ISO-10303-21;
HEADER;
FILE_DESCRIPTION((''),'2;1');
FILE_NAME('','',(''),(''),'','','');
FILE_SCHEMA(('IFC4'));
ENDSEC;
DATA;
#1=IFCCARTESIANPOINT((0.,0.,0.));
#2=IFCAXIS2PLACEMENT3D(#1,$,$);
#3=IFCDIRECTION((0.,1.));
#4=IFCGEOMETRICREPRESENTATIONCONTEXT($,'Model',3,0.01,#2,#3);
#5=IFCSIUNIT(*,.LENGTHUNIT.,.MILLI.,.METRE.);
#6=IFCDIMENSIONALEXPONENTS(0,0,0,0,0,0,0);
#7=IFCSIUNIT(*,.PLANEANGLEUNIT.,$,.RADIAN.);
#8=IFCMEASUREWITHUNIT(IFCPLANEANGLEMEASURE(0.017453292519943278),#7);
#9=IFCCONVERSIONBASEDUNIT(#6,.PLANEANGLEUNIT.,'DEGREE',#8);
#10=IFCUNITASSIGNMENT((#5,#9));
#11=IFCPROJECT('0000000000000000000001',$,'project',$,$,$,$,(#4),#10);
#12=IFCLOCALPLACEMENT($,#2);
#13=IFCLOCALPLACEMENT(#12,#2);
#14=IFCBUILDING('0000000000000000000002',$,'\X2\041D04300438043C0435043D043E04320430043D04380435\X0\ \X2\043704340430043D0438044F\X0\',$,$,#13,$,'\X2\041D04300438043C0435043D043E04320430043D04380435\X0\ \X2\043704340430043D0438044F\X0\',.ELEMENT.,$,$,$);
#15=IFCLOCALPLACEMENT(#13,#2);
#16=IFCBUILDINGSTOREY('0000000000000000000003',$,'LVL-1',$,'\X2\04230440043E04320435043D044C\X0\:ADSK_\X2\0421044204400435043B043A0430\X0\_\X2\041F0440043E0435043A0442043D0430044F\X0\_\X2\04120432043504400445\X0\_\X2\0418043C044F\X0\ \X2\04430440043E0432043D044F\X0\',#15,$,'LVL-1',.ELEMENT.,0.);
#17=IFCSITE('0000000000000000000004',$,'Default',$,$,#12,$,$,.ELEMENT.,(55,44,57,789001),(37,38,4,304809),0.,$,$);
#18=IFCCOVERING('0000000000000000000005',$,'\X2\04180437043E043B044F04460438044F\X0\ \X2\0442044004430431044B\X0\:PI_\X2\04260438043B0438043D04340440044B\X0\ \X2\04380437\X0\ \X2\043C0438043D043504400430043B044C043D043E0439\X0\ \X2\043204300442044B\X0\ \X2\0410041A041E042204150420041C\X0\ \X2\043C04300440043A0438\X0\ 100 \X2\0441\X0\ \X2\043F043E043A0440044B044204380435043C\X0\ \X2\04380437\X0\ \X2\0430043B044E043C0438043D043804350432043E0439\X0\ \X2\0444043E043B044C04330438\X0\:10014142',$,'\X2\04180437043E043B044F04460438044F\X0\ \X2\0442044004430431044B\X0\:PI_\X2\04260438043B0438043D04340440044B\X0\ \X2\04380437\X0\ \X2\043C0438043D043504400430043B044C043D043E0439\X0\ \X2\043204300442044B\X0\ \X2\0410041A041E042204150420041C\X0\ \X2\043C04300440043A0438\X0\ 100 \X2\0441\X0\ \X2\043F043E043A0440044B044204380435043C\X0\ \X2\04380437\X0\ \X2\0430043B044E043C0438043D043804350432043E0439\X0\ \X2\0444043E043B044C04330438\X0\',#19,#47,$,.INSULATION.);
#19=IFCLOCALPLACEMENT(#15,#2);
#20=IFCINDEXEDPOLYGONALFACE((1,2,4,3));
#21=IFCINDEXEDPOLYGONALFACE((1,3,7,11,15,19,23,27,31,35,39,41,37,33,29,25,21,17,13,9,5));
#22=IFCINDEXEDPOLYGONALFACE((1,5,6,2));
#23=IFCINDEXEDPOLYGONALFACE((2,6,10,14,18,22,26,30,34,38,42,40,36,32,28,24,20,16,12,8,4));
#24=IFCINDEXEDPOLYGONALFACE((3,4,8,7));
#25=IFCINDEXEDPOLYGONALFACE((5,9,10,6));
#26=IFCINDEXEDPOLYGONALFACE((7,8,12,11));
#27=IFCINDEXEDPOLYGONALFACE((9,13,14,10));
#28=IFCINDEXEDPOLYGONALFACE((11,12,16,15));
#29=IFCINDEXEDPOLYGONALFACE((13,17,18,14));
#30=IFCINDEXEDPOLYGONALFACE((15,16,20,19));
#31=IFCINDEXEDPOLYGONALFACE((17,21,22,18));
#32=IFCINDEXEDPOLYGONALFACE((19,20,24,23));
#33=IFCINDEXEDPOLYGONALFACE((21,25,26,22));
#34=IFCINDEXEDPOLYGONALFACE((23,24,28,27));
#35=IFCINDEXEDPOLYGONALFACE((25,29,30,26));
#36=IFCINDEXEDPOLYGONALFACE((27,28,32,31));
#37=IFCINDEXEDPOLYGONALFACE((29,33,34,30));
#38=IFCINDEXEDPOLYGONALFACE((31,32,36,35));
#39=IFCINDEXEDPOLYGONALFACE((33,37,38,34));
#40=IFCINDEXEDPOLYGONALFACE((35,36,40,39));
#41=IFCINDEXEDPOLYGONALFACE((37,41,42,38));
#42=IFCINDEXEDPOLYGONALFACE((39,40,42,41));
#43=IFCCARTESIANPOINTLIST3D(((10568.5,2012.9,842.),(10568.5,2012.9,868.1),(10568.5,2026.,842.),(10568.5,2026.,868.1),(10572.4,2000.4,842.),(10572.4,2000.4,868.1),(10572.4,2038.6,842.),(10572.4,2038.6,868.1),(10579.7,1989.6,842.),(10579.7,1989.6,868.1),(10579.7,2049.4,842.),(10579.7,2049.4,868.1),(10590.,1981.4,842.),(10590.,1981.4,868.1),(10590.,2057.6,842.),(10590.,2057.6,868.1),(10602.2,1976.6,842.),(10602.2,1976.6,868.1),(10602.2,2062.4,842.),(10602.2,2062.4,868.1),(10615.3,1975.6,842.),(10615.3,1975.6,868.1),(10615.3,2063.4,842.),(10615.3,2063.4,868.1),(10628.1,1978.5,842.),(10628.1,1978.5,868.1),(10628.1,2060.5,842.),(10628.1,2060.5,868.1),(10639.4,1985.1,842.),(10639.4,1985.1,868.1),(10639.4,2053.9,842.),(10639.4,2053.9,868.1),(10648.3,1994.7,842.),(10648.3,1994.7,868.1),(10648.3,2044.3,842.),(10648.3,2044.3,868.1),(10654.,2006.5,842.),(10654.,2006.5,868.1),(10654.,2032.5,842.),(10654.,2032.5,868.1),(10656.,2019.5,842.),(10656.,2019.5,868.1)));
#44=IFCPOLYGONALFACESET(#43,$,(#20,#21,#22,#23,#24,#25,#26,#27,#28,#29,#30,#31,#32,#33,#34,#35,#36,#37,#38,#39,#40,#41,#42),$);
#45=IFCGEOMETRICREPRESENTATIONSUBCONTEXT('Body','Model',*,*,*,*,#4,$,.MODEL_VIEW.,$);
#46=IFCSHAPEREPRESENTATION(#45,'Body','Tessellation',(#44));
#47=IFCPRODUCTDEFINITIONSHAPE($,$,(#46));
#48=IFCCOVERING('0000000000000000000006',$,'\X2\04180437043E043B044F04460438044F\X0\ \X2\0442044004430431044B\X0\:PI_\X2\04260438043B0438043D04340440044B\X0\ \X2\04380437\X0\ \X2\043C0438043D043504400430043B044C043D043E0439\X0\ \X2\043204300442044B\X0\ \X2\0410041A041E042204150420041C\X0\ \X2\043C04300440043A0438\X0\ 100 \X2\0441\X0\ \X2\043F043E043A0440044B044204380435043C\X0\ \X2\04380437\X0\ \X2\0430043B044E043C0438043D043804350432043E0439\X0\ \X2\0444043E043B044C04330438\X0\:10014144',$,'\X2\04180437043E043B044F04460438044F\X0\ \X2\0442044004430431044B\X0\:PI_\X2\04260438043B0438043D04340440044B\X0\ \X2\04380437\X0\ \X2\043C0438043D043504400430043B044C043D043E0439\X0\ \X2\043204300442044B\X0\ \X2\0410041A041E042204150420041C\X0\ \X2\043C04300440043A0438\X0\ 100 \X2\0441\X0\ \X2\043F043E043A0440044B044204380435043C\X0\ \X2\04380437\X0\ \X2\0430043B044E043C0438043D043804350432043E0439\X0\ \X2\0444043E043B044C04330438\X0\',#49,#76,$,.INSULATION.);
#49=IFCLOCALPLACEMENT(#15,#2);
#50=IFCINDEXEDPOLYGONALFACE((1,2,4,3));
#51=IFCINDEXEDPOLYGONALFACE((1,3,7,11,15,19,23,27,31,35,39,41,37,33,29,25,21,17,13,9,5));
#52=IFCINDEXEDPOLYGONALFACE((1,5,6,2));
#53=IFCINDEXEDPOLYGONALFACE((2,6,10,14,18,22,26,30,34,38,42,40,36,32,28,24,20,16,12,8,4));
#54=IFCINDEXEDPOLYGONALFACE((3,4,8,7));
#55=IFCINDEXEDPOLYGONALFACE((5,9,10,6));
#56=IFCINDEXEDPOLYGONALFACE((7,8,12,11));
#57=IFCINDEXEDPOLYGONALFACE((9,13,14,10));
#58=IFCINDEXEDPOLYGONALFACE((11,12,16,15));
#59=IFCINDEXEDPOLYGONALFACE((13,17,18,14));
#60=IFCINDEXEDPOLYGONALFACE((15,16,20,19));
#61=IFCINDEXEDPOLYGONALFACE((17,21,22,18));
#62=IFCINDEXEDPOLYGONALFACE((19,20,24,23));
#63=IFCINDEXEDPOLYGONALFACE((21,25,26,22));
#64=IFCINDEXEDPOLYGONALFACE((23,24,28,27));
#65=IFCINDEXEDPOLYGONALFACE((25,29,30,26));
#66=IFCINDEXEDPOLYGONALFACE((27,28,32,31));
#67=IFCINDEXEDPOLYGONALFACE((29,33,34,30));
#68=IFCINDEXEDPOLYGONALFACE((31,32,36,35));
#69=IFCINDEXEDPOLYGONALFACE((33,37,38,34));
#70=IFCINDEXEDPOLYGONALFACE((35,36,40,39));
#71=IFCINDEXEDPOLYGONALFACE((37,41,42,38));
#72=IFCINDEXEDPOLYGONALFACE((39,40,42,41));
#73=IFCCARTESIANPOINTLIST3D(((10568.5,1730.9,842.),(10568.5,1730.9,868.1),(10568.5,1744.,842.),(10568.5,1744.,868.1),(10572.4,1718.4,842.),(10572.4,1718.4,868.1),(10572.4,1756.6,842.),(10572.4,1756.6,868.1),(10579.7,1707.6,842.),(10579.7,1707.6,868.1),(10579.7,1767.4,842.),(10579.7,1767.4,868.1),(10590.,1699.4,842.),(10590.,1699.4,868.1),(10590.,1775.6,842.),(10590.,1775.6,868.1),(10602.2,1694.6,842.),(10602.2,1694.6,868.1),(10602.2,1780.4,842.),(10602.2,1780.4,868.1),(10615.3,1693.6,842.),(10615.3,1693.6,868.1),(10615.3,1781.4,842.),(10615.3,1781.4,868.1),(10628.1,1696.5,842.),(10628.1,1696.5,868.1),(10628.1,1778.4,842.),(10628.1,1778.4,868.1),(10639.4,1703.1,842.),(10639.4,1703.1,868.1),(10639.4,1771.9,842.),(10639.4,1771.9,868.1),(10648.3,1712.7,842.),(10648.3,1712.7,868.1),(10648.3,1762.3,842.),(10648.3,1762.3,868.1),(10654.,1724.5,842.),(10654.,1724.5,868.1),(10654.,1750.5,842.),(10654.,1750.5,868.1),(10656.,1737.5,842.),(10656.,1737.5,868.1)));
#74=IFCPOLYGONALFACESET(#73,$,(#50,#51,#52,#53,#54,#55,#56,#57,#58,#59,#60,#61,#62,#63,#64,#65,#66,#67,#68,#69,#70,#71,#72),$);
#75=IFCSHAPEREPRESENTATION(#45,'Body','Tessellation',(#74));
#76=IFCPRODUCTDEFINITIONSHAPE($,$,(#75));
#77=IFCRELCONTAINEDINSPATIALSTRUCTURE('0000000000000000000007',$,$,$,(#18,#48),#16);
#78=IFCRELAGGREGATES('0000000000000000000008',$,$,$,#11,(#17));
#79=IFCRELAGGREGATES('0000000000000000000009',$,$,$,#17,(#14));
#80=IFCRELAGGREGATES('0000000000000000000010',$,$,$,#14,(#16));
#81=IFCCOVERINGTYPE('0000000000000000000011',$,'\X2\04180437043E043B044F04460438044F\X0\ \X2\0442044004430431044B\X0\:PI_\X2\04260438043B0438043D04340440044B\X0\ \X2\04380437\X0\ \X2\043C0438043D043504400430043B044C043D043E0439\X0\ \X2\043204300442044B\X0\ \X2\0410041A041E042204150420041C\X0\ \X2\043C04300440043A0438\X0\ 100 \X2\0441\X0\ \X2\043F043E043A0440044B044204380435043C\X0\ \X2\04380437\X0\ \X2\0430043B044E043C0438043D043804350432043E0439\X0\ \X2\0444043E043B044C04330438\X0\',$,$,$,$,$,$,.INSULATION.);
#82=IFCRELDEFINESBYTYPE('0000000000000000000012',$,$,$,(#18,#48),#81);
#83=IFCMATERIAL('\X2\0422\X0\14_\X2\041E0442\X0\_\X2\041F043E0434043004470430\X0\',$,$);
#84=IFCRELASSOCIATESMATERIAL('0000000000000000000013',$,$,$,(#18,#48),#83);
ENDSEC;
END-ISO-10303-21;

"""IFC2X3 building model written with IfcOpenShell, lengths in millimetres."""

from ifc_helpers import new_model, entity, si_unit, converted_unit, direction, frame, frame_2d, origin, place, context, subcontext, project, spatial, circle, extrude, material, type_object, element, save


model = new_model("IFC2X3")

# Units and contexts
model_context = context("Model", 3, precision=0.01, world=origin(), true_north=direction((0.0, 1.0)))
body_context = subcontext(model_context, "Body", "Model", "MODEL_VIEW")
ifc_project = project(units=[si_unit("LENGTHUNIT", "METRE", prefix="MILLI"), converted_unit("PLANEANGLEUNIT", "DEGREE", entity("IfcPlaneAngleMeasure", 0.017453292519943278), si_unit("PLANEANGLEUNIT", "RADIAN"), dimensions=[0, 0, 0, 0, 0, 0, 0])], contexts=[model_context])

# Site, building, storey
site_placement = place(None, origin())
site = spatial("IfcSite", under=ifc_project, at=site_placement, Name="Default", CompositionType="ELEMENT", RefLatitude=(55, 44, 57, 789001), RefLongitude=(37, 38, 4, 304809), RefElevation=0.0)
building_placement = place(site_placement, origin())
building = spatial("IfcBuilding", under=site, at=building_placement, Name="Наименование здания", LongName="Наименование здания", CompositionType="ELEMENT")
storey_placement = place(building_placement, origin())
storey = spatial("IfcBuildingStorey", under=building, at=storey_placement, Name="LVL-1", ObjectType="Уровень:ADSK_Стрелка_Проектная_Вверх_Имя уровня", LongName="LVL-1", CompositionType="ELEMENT", Elevation=0.0)

# Coverings
covering_type = type_object("IfcCoveringType", Name="Изоляция трубы:PI_Цилиндры из минеральной ваты АКОТЕРМ марки 100 с покрытием из алюминиевой фольги", PredefinedType="INSULATION")
ifc_material_1 = material(Name="Т14_От_Подача")
covering_1_placement = place(storey_placement, origin())
element("IfcCovering", 1, at=covering_1_placement, inside=storey, type_object=covering_type, material=ifc_material_1, Name="Изоляция трубы:PI_Цилиндры из минеральной ваты АКОТЕРМ марки 100 с покрытием из алюминиевой фольги:10014142", ObjectType="Изоляция трубы:PI_Цилиндры из минеральной ваты АКОТЕРМ марки 100 с покрытием из алюминиевой фольги", PredefinedType="INSULATION", context=body_context, shape_type="SweptSolid", body=[
    extrude(circle(Radius=44.0, at=frame_2d((0.0, 0.0), x_axis=(1.0, 0.0))), frame((10612.0, 2019.5, 842.0)), (0.0, 0.0, 1.0), 26.1),
])
covering_2_placement = place(storey_placement, origin())
element("IfcCovering", 2, at=covering_2_placement, inside=storey, type_object=covering_type, material=ifc_material_1, Name="Изоляция трубы:PI_Цилиндры из минеральной ваты АКОТЕРМ марки 100 с покрытием из алюминиевой фольги:10014144", ObjectType="Изоляция трубы:PI_Цилиндры из минеральной ваты АКОТЕРМ марки 100 с покрытием из алюминиевой фольги", PredefinedType="INSULATION", context=body_context, shape_type="SweptSolid", body=[
    extrude(circle(Radius=44.0, at=frame_2d((0.0, 0.0), x_axis=(1.0, 0.0))), frame((10612.0, 1737.5, 842.0)), (0.0, 0.0, 1.0), 26.1),
])

save(model, "model.ifc")
